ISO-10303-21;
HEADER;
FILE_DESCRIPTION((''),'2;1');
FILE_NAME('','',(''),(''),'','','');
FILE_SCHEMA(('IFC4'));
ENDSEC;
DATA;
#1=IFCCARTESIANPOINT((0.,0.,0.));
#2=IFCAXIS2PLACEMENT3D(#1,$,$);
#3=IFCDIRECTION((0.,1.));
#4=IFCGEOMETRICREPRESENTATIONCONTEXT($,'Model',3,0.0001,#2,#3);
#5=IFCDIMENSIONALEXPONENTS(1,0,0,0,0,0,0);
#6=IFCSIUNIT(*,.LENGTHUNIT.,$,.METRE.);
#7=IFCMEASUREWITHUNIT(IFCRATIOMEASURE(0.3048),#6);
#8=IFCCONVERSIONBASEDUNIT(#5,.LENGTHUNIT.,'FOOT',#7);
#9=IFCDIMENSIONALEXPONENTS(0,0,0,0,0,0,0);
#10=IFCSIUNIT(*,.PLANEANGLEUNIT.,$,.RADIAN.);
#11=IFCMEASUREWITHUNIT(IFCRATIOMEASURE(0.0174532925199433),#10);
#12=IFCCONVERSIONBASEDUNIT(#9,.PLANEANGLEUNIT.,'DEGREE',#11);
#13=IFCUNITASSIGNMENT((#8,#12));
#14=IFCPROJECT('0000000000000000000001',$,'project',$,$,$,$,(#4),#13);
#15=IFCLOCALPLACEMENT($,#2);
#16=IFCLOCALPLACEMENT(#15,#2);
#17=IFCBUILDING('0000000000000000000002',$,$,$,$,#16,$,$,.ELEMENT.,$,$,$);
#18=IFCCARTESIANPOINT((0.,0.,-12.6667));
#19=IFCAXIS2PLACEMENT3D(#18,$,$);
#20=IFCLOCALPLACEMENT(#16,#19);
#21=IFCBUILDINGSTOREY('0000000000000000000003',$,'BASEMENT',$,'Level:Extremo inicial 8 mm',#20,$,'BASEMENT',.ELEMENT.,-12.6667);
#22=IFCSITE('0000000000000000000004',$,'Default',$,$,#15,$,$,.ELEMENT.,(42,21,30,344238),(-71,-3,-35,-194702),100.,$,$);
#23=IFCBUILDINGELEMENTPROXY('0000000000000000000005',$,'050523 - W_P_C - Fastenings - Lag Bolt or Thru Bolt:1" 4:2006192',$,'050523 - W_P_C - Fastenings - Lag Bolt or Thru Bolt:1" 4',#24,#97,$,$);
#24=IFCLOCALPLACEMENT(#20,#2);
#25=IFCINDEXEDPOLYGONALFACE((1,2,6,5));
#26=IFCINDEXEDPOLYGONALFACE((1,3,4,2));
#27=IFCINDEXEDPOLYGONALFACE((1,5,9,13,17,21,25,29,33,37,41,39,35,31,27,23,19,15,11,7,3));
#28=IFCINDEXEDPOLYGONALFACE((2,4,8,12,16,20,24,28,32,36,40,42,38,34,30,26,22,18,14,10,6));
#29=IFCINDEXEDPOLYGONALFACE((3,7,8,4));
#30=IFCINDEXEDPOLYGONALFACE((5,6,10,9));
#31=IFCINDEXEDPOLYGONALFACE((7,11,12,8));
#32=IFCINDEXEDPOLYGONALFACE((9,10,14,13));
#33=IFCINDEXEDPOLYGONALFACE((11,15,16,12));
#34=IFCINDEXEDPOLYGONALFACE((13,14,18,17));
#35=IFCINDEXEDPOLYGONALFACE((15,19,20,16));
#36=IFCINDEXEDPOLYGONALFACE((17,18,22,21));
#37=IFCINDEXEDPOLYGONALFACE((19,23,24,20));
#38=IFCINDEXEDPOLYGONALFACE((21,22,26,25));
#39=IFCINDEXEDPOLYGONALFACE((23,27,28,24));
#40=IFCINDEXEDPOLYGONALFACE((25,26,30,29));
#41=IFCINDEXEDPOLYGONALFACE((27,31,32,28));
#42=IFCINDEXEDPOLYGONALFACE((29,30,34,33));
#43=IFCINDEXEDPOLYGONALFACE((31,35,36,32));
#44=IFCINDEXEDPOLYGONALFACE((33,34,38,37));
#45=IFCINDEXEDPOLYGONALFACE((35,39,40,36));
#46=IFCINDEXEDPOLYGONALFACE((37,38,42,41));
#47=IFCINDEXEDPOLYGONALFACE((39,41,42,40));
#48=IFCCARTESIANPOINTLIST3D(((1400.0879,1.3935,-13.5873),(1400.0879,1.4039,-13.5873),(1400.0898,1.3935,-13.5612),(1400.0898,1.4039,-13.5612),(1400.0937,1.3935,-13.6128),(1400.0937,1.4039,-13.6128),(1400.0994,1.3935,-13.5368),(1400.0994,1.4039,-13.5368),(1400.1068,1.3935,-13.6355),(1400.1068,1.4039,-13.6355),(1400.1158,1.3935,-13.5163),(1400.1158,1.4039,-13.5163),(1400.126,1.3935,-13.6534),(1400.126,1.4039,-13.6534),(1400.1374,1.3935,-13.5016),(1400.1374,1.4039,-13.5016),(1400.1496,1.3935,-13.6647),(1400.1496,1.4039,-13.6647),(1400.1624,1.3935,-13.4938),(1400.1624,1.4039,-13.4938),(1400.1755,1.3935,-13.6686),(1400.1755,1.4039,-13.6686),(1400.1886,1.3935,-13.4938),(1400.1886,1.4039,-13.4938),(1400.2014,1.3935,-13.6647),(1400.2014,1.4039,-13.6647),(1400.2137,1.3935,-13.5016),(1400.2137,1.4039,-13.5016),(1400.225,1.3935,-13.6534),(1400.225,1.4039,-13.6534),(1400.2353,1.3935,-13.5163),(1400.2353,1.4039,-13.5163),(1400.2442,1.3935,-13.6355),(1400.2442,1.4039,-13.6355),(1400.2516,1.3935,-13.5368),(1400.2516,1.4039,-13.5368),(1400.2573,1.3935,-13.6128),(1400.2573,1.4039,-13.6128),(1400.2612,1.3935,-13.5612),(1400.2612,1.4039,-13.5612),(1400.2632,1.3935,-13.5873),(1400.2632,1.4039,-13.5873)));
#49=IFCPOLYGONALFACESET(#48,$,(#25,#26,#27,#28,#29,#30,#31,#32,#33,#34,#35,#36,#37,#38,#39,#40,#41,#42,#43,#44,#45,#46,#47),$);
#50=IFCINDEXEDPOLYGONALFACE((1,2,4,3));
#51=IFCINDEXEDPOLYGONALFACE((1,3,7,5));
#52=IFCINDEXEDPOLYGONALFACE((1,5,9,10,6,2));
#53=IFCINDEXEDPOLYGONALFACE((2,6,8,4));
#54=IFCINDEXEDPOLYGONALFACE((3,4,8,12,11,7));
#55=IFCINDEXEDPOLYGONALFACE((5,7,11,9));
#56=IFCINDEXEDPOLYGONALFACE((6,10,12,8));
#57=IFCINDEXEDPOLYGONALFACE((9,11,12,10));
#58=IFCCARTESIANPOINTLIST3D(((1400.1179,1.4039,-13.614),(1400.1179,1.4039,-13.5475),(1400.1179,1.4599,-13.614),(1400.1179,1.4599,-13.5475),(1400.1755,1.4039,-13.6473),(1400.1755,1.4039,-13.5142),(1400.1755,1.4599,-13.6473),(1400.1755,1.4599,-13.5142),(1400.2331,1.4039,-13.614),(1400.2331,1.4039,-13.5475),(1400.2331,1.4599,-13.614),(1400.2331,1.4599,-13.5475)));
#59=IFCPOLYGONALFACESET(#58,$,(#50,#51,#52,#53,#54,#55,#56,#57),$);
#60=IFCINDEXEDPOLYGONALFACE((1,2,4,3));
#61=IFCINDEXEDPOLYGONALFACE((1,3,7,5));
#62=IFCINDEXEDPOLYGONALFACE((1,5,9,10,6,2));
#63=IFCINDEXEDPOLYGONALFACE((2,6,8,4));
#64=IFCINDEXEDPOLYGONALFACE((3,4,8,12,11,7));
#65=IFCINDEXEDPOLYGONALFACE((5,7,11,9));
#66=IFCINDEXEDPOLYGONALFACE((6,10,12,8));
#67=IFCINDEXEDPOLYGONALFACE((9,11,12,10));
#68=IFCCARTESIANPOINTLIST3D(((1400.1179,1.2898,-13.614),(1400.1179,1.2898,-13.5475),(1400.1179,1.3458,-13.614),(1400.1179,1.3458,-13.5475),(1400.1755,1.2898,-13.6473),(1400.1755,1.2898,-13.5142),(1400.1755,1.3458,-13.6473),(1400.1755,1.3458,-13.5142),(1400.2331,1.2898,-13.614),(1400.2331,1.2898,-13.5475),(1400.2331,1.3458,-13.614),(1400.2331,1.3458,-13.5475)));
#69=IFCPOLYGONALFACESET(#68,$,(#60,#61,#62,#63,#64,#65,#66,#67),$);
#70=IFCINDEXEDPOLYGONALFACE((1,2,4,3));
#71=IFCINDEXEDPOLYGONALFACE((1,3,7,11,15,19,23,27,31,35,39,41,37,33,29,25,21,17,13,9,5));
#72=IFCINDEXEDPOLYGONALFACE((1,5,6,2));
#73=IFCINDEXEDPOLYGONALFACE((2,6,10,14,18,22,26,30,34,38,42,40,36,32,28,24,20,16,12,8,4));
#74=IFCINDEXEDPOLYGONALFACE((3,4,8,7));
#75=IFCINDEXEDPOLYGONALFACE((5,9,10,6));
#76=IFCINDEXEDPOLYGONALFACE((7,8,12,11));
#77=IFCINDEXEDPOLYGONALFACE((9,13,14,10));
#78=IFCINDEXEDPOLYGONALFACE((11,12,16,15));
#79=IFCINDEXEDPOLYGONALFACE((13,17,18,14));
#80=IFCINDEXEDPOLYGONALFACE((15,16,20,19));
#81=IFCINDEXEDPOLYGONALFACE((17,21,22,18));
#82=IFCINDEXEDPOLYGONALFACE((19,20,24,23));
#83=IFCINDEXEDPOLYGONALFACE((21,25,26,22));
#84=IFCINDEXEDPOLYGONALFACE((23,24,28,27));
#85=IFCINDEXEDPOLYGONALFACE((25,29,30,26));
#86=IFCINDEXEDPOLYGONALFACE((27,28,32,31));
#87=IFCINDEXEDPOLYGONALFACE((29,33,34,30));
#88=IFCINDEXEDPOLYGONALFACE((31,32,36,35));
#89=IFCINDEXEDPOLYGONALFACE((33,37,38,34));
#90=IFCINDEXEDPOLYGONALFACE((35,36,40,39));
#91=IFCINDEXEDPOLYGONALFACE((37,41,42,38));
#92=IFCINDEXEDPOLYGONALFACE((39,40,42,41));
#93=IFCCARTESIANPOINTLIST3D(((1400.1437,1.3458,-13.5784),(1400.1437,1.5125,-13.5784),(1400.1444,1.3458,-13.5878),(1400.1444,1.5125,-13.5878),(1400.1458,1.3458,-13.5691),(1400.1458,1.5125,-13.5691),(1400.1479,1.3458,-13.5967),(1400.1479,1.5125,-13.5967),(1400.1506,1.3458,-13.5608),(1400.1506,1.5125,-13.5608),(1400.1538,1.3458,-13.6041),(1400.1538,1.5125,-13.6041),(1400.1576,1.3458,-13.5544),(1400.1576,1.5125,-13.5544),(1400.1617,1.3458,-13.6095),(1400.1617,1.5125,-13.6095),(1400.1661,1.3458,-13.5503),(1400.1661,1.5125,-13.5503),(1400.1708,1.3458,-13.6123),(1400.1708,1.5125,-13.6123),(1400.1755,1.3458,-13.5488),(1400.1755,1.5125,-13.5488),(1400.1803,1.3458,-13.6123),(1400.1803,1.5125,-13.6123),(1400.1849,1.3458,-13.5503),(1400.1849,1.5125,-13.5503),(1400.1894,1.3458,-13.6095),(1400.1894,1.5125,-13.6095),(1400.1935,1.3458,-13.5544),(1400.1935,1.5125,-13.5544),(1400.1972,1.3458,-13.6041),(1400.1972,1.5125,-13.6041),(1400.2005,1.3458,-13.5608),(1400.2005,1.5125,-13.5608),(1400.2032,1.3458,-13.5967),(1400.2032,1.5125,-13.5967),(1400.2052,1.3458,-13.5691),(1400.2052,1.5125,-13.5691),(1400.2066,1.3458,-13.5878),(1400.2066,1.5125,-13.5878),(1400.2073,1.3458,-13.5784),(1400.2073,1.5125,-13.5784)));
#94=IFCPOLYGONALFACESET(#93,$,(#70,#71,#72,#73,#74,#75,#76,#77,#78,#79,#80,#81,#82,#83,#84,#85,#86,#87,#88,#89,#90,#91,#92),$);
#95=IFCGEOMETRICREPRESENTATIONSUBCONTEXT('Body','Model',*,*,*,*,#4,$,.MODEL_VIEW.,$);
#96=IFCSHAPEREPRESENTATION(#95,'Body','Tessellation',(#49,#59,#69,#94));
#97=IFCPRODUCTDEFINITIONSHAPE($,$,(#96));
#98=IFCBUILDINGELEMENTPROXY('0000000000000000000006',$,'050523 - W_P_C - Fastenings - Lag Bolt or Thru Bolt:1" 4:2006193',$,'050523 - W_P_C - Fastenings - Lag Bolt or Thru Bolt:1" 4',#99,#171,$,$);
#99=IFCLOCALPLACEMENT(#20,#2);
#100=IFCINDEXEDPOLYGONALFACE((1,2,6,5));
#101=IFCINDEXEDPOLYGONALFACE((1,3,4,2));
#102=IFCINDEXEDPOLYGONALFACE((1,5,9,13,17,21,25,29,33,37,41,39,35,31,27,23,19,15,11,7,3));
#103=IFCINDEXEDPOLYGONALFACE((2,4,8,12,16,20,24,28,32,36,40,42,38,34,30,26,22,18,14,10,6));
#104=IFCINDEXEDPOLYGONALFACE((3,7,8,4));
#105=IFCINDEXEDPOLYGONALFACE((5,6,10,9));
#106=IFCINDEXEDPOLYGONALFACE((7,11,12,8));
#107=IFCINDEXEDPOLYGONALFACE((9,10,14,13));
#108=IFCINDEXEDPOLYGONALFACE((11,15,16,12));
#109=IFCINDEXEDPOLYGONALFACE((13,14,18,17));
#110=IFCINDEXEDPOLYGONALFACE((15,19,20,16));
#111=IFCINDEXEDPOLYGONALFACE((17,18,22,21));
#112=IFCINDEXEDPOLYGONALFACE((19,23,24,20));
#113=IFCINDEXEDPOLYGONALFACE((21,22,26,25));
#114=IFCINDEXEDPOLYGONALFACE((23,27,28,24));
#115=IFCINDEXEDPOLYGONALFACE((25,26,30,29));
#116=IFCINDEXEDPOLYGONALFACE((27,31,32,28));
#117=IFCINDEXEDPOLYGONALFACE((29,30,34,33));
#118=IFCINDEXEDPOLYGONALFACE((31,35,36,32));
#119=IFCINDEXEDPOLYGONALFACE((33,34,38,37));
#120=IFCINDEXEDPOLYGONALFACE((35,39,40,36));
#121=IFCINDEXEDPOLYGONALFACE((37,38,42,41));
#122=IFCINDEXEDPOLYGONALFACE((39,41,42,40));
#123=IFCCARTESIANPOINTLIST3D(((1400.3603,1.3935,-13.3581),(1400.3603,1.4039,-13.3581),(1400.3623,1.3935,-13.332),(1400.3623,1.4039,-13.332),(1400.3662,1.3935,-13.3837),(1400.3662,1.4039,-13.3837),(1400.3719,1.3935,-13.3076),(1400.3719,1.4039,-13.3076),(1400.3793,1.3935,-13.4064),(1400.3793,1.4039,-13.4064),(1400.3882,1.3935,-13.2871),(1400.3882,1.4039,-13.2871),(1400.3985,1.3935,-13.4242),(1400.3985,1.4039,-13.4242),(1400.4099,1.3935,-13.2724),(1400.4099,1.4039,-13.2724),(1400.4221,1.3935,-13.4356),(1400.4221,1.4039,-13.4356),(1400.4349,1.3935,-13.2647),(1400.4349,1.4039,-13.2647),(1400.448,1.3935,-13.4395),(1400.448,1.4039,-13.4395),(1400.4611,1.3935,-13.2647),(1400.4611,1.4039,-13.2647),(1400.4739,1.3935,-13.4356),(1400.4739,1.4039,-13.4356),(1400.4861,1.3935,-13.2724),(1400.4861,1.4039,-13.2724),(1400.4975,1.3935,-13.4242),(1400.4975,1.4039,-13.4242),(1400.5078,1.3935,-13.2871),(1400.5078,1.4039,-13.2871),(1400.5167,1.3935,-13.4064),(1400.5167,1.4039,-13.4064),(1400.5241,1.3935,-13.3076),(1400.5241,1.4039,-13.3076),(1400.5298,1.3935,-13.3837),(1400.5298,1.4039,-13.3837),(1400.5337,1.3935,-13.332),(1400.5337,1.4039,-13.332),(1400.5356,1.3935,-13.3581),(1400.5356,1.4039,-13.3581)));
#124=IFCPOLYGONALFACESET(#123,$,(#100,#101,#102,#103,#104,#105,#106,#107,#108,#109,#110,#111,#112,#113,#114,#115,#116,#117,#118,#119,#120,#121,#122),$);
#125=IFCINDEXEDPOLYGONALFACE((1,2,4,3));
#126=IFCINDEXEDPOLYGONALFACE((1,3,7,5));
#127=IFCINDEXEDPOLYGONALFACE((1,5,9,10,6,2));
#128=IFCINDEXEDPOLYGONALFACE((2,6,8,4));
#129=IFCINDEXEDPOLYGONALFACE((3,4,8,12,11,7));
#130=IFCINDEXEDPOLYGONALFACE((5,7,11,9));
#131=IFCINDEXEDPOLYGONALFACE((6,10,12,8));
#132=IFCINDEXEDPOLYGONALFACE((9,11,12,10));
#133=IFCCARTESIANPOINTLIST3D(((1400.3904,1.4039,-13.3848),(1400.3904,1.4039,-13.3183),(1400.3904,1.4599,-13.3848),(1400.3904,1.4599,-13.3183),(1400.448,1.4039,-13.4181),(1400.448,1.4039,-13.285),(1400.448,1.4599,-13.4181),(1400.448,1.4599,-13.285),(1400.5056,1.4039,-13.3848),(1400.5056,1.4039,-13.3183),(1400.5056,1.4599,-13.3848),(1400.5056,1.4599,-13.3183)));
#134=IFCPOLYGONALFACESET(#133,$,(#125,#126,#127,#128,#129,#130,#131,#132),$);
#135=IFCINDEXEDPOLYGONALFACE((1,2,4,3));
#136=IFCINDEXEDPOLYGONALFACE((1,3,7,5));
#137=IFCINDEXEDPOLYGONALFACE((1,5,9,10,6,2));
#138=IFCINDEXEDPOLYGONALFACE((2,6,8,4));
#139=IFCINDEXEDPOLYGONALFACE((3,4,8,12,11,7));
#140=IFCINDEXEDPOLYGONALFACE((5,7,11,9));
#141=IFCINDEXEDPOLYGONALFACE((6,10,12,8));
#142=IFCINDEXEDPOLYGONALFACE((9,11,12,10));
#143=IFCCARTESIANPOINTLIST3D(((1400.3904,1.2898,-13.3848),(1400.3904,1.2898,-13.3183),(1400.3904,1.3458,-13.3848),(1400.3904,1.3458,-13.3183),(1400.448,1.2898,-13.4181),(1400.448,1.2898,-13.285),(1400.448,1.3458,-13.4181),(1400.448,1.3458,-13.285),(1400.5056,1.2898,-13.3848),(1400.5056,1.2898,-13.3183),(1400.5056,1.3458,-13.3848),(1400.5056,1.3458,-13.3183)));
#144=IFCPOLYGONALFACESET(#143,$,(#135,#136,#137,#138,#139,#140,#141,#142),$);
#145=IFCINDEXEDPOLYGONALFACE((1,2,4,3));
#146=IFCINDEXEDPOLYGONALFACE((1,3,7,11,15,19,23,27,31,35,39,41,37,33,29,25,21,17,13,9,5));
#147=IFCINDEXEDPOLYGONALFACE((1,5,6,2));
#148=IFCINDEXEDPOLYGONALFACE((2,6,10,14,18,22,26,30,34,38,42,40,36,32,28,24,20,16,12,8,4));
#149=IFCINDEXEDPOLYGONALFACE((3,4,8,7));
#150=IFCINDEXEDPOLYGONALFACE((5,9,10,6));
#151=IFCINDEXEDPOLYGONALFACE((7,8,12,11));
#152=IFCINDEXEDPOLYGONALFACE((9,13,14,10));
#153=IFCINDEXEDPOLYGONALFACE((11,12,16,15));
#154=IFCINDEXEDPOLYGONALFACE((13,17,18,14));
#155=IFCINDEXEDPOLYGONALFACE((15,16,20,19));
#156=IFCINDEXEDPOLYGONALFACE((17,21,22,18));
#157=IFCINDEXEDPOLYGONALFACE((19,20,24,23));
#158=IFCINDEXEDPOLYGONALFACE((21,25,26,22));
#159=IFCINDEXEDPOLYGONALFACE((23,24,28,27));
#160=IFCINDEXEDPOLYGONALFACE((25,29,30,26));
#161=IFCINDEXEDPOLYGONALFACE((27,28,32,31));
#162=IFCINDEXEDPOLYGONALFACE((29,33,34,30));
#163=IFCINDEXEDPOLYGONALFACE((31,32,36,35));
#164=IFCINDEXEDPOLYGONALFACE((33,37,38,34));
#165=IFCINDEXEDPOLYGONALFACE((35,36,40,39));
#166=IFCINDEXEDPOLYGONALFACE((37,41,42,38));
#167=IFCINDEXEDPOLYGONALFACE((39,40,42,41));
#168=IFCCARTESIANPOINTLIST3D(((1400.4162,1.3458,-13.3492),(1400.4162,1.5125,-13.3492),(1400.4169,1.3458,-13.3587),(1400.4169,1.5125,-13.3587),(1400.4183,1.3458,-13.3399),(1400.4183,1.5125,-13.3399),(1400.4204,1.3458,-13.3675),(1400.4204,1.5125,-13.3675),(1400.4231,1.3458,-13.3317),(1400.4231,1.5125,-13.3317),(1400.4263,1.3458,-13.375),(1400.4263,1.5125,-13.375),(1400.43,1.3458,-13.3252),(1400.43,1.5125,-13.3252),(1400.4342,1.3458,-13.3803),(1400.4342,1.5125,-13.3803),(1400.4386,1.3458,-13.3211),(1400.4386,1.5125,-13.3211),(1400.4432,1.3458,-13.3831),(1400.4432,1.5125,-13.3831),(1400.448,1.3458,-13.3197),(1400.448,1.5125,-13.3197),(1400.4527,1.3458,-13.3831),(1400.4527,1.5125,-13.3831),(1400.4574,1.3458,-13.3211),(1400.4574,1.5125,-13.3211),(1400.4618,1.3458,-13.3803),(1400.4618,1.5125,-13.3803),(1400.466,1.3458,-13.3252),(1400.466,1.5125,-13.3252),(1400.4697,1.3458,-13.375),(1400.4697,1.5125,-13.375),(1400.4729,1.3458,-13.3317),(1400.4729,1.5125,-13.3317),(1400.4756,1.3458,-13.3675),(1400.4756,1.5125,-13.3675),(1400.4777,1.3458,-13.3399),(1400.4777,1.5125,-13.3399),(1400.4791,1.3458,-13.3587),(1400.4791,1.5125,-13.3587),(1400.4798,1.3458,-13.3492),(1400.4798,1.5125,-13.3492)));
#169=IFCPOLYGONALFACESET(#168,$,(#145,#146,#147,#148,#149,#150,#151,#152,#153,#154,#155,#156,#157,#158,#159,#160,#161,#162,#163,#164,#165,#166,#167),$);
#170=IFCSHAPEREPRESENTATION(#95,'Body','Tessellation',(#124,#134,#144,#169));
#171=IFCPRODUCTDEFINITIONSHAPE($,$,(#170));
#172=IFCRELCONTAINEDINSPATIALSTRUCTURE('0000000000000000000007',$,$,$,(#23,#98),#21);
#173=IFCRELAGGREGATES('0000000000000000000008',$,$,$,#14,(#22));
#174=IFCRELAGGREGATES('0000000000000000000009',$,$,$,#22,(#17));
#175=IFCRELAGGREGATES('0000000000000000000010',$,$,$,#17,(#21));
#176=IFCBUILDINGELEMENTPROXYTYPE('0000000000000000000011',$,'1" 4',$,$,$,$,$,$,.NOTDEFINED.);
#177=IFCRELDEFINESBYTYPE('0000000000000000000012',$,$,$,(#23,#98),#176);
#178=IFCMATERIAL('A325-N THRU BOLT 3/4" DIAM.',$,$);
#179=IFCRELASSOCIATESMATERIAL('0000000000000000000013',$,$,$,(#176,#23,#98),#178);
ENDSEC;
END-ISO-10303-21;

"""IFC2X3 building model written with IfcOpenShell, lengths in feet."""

from ifc_helpers import new_model, entity, si_unit, converted_unit, direction, frame, frame_2d, origin, place, context, subcontext, project, spatial, polyline, circle, outline, extrude, source, transform, mapped, material, type_object, type_shapes, element, save


model = new_model("IFC2X3")

# Units and contexts
model_context = context("Model", 3, precision=0.0001, world=origin(), true_north=direction((0.0, 1.0)))
body_context = subcontext(model_context, "Body", "Model", "MODEL_VIEW")
ifc_project = project(units=[converted_unit("LENGTHUNIT", "FOOT", entity("IfcRatioMeasure", 0.3048), si_unit("LENGTHUNIT", "METRE"), dimensions=[1, 0, 0, 0, 0, 0, 0]), converted_unit("PLANEANGLEUNIT", "DEGREE", entity("IfcRatioMeasure", 0.0174532925199433), si_unit("PLANEANGLEUNIT", "RADIAN"), dimensions=[0, 0, 0, 0, 0, 0, 0])], contexts=[model_context])

# Site, building, storey
site_placement = place(None, origin())
site = spatial("IfcSite", under=ifc_project, at=site_placement, Name="Default", CompositionType="ELEMENT", RefLatitude=(42, 21, 30, 344238), RefLongitude=(-71, -3, -35, -194702), RefElevation=100.0)
building_placement = place(site_placement, origin())
building = spatial("IfcBuilding", under=site, at=building_placement, CompositionType="ELEMENT")
storey_placement = place(building_placement, frame((0.0, 0.0, -12.6667)))
storey = spatial("IfcBuildingStorey", under=building, at=storey_placement, Name="BASEMENT", ObjectType="Level:Extremo inicial 8 mm", LongName="BASEMENT", CompositionType="ELEMENT", Elevation=-12.6667)

# Building element proxies
ifc_material_1 = material(Name="A325-N THRU BOLT 3/4\" DIAM.")
building_element_proxy_type_1 = type_object("IfcBuildingElementProxyType", Name="1\" 4", PredefinedType="NOTDEFINED", material=ifc_material_1)
shared_shape_1 = source(origin(), body_context, "Body", "SweptSolid", [
    extrude(circle(Radius=0.0879, at=frame_2d((0.0, 0.0), x_axis=(1.0, 0.0))), frame((0.0, 0.0, -0.0581), z_axis=(0.0, 0.0, 1.0), x_axis=(0.0, -1.0, 0.0)), (0.0, 0.0, 1.0), 0.0104),
    extrude(outline(polyline([(-0.0333, -0.0576), (0.0333, -0.0576), (0.0665, 0.0), (0.0333, 0.0576), (-0.0333, 0.0576), (-0.0665, 0.0), (-0.0333, -0.0576)])), frame((0.0, 0.0, -0.1141), z_axis=(0.0, 0.0, 1.0), x_axis=(0.866025, -0.5, 0.0)), (0.0, 0.0, 1.0), 0.056),
    extrude(outline(polyline([(-0.0333, -0.0576), (0.0333, -0.0576), (0.0665, 0.0), (0.0333, 0.0576), (-0.0333, 0.0576), (-0.0665, 0.0), (-0.0333, -0.0576)])), frame((0.0, 0.0, 0.0), z_axis=(0.0, 0.0, 1.0), x_axis=(0.0, -1.0, 0.0)), (0.0, 0.0, 1.0), 0.056),
    extrude(circle(Radius=0.0319, at=frame_2d((0.0, 0.0), x_axis=(1.0, 0.0))), frame((0.0, 0.0, -0.1667), z_axis=(0.0, 0.0, 1.0), x_axis=(0.0, 1.0, 0.0)), (0.0, 0.0, 1.0), 0.1667),
])
type_shapes(building_element_proxy_type_1, [shared_shape_1])
for number, where, z_axis, x_axis, name in (
    (1, (1400.1755, 1.3458, -13.5807), (0.0, -1.0, 0.0), (1.0, 0.0, 0.0), "050523 - W_P_C - Fastenings - Lag Bolt or Thru Bolt:1\" 4:2006192"),
    (2, (1400.448, 1.3458, -13.3516), (0.0, -1.0, 0.0), (1.0, 0.0, 0.0), "050523 - W_P_C - Fastenings - Lag Bolt or Thru Bolt:1\" 4:2006193"),
):
    element("IfcBuildingElementProxy", number, at=place(storey_placement, frame(where, z_axis=z_axis, x_axis=x_axis)), inside=storey, type_object=building_element_proxy_type_1, material=ifc_material_1, Name=name, ObjectType="050523 - W_P_C - Fastenings - Lag Bolt or Thru Bolt:1\" 4", context=body_context, shape_type="MappedRepresentation", body=[
        mapped(shared_shape_1, transform((0.0, 0.0, 0.0), scale=1.0)),
    ])

save(model, "model.ifc")
